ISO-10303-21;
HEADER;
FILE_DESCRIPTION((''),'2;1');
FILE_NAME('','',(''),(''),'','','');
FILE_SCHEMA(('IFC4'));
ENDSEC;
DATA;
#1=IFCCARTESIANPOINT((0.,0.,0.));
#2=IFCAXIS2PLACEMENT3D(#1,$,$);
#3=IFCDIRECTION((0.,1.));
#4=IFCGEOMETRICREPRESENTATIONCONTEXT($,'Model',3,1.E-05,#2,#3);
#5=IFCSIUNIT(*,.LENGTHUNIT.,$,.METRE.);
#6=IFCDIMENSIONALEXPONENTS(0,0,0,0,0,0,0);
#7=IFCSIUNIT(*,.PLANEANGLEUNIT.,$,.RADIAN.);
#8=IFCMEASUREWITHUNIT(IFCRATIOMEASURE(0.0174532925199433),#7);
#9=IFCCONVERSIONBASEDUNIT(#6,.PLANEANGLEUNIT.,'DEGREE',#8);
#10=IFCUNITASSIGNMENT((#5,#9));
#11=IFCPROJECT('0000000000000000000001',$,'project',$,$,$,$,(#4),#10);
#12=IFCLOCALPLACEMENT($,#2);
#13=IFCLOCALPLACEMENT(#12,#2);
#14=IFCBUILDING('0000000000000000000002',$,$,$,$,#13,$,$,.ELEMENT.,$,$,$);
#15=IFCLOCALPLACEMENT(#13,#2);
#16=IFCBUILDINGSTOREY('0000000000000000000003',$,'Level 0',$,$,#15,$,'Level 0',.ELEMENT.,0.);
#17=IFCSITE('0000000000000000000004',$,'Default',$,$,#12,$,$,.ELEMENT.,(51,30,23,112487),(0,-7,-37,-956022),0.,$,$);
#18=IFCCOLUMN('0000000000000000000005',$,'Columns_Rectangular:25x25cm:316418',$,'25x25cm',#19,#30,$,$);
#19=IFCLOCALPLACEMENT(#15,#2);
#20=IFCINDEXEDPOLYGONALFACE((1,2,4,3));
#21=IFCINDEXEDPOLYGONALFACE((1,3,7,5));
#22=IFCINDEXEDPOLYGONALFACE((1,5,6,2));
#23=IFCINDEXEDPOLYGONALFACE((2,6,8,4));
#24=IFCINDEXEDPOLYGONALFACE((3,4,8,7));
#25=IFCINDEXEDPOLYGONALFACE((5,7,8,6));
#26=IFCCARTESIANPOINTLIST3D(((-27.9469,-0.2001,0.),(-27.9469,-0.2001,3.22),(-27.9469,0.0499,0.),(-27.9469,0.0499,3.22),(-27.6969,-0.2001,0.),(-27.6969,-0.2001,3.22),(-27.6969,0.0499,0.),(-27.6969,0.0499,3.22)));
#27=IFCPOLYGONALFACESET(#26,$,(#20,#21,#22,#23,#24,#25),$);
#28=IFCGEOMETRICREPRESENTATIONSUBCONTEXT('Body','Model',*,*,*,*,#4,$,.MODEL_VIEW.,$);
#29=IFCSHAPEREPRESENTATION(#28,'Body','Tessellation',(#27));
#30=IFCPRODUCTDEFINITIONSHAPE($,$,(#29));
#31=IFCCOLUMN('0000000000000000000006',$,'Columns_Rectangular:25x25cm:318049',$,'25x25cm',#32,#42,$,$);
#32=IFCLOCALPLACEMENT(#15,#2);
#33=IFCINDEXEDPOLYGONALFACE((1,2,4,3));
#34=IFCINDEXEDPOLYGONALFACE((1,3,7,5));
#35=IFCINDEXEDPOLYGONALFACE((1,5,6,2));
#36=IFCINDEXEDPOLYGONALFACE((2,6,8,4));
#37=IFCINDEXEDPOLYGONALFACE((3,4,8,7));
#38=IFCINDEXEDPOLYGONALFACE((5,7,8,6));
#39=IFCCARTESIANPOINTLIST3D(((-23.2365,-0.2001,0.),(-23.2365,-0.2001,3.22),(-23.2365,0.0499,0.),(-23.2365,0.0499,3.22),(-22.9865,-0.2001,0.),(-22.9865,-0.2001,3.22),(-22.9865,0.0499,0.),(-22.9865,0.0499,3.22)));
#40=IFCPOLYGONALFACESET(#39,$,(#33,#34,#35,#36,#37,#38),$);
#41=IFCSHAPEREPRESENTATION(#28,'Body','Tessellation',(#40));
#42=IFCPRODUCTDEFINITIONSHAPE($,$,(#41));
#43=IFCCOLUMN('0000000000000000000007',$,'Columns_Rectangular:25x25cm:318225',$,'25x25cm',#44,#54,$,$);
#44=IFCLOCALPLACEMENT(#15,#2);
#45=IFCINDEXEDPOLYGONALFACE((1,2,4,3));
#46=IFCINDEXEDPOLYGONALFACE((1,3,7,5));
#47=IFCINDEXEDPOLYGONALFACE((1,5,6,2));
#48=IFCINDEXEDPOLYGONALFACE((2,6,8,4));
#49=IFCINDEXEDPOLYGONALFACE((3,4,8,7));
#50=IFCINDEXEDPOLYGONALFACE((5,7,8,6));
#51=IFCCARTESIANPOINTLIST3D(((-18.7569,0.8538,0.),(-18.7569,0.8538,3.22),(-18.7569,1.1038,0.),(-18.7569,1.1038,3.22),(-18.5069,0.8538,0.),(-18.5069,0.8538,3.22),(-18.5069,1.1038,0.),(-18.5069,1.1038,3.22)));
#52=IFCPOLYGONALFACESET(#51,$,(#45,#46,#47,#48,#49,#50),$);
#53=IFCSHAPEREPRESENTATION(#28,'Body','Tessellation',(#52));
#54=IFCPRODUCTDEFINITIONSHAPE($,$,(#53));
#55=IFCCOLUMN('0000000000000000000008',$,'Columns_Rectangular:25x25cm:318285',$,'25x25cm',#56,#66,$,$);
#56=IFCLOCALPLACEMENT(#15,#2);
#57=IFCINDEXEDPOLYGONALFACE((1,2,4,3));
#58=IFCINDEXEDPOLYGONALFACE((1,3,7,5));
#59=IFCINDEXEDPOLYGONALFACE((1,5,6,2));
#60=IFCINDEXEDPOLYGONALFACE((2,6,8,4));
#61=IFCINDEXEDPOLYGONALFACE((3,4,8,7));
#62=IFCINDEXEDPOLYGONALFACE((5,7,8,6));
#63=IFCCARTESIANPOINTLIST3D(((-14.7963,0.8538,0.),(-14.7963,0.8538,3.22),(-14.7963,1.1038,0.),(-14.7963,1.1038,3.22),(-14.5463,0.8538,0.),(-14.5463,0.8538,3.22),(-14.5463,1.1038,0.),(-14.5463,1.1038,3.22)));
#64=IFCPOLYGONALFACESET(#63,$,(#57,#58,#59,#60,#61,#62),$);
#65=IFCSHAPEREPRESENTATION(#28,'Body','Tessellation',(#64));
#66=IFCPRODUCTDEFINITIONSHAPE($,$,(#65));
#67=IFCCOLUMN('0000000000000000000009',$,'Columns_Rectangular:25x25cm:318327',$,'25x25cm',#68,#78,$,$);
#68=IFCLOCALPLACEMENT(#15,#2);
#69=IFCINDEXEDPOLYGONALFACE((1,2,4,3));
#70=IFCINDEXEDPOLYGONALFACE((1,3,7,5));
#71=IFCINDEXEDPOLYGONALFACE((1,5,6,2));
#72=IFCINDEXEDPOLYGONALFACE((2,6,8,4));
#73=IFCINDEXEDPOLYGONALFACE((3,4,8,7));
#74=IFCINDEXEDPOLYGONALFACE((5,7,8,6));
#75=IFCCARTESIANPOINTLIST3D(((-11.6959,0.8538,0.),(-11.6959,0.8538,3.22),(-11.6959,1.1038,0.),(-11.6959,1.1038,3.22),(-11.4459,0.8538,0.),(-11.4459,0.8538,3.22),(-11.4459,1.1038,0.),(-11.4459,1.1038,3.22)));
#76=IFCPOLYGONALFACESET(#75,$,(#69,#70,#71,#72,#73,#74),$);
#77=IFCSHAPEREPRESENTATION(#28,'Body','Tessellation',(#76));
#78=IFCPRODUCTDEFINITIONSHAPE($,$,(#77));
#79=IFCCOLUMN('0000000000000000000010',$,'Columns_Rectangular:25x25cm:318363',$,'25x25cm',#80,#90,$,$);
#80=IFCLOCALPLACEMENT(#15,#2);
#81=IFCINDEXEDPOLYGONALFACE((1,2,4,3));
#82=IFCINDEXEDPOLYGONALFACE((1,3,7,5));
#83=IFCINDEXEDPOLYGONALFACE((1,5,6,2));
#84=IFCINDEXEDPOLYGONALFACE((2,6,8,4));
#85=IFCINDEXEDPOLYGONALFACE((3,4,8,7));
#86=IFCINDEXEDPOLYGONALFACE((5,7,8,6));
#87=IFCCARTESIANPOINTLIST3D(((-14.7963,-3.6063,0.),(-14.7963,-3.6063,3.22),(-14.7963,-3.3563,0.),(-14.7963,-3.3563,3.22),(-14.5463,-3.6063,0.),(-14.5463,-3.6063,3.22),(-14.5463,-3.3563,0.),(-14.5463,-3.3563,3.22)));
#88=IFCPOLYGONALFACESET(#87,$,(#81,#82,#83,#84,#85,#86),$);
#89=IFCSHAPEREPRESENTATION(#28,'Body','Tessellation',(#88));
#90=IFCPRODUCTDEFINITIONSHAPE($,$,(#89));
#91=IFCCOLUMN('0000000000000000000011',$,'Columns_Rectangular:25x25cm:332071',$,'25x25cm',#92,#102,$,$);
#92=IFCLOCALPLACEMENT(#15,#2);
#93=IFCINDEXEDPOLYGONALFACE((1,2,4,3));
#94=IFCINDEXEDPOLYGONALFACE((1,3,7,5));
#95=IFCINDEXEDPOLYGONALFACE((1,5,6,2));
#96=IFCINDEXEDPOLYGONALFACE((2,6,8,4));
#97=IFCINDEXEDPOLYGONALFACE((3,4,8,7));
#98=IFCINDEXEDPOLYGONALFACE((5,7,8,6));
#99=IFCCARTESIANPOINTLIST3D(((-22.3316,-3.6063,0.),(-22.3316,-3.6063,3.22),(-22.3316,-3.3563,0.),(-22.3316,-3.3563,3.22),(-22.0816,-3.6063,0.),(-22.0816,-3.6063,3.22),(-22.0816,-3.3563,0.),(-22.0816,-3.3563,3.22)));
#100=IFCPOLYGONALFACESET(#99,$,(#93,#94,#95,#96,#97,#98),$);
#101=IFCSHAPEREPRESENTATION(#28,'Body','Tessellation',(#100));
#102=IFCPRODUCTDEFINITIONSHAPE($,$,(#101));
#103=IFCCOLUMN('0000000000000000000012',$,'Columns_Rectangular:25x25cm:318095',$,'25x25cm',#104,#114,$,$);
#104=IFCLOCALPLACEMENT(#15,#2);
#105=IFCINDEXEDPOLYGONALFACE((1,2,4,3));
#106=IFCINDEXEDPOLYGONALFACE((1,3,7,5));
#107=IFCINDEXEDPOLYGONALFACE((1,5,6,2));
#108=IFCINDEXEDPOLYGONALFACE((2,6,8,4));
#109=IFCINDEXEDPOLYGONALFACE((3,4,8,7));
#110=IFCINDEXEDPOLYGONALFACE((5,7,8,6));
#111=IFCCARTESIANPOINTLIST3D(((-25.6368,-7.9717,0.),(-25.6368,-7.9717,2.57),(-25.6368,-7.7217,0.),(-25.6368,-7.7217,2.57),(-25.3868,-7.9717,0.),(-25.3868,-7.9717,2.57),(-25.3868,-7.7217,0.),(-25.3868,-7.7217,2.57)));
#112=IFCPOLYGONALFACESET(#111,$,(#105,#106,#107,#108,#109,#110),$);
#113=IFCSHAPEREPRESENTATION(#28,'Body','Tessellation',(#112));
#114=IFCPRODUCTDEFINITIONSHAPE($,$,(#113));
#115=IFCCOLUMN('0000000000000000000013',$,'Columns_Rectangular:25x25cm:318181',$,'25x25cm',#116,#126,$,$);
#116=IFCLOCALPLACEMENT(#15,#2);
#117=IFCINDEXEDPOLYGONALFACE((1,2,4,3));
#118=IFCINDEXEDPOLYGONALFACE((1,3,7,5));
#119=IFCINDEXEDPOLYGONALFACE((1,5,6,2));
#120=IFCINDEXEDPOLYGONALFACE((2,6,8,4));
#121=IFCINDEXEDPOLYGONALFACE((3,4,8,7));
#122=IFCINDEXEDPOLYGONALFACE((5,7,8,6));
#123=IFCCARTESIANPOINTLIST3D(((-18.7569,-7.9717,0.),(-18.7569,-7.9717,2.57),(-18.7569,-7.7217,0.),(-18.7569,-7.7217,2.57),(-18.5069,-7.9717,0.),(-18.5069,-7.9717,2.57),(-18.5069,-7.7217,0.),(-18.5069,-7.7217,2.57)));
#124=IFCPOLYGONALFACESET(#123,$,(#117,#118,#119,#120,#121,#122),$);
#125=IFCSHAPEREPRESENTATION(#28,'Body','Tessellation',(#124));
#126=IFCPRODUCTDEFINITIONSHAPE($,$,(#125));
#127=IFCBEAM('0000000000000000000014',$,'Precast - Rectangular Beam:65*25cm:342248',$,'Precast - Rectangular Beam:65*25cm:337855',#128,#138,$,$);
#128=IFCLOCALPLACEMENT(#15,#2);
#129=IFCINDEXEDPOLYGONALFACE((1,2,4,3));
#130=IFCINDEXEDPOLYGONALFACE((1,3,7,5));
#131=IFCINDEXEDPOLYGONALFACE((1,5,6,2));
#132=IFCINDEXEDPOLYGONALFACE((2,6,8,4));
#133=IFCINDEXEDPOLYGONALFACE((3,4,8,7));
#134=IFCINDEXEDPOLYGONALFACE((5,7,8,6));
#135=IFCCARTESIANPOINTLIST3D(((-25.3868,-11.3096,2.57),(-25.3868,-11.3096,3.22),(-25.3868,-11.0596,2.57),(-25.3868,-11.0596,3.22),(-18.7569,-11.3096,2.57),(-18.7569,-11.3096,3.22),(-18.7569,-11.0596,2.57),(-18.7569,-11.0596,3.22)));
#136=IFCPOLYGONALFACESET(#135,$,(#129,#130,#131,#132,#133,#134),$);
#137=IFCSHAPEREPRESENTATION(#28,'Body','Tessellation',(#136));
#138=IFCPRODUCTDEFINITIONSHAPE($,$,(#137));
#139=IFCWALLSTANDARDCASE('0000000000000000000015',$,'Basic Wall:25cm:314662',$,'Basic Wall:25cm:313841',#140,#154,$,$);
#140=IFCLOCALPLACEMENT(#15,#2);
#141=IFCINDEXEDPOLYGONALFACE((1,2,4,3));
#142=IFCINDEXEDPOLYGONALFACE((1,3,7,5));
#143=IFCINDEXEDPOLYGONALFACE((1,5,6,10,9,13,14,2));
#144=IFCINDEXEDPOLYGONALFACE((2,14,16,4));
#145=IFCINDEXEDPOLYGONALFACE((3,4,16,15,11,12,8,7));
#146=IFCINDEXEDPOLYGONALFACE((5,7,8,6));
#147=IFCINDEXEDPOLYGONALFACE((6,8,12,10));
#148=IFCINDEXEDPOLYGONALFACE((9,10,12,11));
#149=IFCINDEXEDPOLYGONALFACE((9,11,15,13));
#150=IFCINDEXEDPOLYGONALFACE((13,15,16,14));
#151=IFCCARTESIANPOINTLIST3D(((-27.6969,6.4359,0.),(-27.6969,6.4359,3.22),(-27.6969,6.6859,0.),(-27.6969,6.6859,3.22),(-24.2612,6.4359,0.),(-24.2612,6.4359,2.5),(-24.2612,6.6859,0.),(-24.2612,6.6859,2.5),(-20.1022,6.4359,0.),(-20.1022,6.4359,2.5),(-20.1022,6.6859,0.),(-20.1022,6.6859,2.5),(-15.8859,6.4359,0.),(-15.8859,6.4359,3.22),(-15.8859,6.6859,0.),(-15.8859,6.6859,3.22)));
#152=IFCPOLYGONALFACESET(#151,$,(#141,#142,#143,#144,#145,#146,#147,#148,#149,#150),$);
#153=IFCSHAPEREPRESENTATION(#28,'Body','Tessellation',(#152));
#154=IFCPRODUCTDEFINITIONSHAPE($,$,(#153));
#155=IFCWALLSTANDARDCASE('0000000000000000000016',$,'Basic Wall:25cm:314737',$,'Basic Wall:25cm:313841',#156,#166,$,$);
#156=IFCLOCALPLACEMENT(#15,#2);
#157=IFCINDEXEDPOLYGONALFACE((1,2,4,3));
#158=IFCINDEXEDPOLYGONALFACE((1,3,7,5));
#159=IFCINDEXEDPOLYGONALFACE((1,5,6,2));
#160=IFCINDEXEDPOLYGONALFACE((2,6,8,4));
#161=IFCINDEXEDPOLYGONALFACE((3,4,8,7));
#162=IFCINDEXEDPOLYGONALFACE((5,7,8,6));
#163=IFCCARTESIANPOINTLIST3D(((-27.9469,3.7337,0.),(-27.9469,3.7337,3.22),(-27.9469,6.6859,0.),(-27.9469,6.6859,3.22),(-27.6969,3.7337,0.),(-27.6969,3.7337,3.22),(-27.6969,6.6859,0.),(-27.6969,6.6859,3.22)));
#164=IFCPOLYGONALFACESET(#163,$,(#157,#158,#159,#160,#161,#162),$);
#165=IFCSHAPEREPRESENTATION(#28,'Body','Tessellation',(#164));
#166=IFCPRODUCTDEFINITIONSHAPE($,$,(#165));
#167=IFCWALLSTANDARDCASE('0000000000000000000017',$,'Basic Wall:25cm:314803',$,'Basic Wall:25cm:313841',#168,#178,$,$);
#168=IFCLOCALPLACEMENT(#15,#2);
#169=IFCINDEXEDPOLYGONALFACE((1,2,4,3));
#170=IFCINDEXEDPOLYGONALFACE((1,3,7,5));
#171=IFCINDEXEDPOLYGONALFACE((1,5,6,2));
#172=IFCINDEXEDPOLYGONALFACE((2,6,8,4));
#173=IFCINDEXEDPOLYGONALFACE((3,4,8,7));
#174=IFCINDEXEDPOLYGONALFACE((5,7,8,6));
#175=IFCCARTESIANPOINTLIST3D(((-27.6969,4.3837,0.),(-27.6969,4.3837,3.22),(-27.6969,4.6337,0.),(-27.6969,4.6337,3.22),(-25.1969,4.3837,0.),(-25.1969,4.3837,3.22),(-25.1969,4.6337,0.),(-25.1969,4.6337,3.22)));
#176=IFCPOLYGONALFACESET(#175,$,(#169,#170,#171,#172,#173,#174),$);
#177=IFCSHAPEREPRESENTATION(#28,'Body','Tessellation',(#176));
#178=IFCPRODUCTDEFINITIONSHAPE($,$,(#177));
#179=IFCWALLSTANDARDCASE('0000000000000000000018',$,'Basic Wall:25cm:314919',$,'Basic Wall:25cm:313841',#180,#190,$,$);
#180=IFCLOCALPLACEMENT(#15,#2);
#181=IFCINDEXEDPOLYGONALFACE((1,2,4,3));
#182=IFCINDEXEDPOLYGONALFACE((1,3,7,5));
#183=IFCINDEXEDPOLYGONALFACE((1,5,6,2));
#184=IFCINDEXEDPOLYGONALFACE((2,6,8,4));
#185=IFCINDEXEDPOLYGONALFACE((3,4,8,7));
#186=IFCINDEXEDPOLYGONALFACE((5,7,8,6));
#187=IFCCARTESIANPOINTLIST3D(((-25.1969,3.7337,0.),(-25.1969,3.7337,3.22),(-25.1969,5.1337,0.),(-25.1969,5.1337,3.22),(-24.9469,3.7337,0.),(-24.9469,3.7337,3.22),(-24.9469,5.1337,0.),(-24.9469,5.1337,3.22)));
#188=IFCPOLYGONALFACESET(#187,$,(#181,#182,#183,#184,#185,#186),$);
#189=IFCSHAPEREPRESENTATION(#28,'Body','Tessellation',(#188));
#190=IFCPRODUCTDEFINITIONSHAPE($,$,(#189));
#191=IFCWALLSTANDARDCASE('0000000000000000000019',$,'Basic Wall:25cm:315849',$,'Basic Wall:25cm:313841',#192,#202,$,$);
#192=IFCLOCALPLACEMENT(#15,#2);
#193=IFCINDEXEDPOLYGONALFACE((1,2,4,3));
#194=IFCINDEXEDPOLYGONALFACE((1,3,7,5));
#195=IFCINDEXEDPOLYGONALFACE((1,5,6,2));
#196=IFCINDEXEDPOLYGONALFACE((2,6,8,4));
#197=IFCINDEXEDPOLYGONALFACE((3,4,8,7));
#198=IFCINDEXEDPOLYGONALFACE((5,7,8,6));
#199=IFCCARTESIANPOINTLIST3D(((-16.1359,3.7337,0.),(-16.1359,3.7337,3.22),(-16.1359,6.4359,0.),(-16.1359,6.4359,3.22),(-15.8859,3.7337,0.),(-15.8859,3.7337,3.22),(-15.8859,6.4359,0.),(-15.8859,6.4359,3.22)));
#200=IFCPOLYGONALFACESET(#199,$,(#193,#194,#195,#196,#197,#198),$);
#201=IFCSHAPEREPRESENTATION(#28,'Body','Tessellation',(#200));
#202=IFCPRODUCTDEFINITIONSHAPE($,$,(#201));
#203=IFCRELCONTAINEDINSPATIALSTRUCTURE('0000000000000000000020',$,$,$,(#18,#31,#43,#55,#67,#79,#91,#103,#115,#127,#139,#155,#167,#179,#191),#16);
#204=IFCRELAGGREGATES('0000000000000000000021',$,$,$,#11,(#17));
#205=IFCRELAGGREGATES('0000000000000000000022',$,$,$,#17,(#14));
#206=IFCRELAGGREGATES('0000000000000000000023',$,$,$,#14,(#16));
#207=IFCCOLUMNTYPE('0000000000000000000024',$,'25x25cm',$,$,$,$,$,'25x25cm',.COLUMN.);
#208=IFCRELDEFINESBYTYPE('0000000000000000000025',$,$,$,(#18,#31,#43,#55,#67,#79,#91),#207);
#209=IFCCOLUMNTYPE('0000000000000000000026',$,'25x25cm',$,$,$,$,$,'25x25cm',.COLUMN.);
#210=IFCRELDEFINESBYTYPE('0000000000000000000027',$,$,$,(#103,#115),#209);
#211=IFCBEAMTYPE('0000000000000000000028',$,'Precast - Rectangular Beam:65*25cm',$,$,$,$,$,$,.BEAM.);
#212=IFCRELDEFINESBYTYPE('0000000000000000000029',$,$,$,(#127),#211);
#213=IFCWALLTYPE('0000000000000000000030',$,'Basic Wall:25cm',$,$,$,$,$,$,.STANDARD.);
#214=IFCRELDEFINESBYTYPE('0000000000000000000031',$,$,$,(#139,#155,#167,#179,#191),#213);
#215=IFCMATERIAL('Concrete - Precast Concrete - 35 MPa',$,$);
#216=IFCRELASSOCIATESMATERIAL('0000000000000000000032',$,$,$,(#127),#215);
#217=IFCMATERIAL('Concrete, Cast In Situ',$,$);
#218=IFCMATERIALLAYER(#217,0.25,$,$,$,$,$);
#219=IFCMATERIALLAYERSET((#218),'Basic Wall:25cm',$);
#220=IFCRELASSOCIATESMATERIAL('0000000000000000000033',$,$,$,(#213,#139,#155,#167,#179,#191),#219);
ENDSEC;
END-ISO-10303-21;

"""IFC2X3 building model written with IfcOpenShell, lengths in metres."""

from ifc_helpers import new_model, entity, si_unit, converted_unit, direction, frame, frame_2d, origin, origin_2d_with_axis, place, context, subcontext, project, spatial, rectangle, extrude, source, transform, mapped, material, layer, layer_set, layer_usage, type_object, type_shapes, element, save


model = new_model("IFC2X3")

# Units and contexts
model_context = context("Model", 3, precision=1e-05, world=origin(), true_north=direction((0.0, 1.0)))
body_context = subcontext(model_context, "Body", "Model", "MODEL_VIEW")
ifc_project = project(units=[si_unit("LENGTHUNIT", "METRE"), converted_unit("PLANEANGLEUNIT", "DEGREE", entity("IfcRatioMeasure", 0.0174532925199433), si_unit("PLANEANGLEUNIT", "RADIAN"), dimensions=[0, 0, 0, 0, 0, 0, 0])], contexts=[model_context])

# Site, building, storey
site_placement = place(None, origin())
site = spatial("IfcSite", under=ifc_project, at=site_placement, Name="Default", CompositionType="ELEMENT", RefLatitude=(51, 30, 23, 112487), RefLongitude=(0, -7, -37, -956022), RefElevation=0.0)
building_placement = place(site_placement, origin())
building = spatial("IfcBuilding", under=site, at=building_placement, CompositionType="ELEMENT")
storey_placement = place(building_placement, origin())
storey = spatial("IfcBuildingStorey", under=building, at=storey_placement, Name="Level 0", LongName="Level 0", CompositionType="ELEMENT", Elevation=0.0)

# Columns
column_type_1 = type_object("IfcColumnType", Name="25x25cm", ElementType="25x25cm", PredefinedType="COLUMN")
shared_shape_1 = source(origin(), body_context, "Body", "SweptSolid", [
    extrude(rectangle(XDim=0.25, YDim=0.25, at=origin_2d_with_axis()), frame((0.0, 0.0, 0.0), z_axis=(0.0, 0.0, 1.0), x_axis=(0.0, -1.0, 0.0)), (0.0, 0.0, 1.0), 3.22),
])
type_shapes(column_type_1, [shared_shape_1])
for number, where, name in (
    (1, (-27.8219, -0.0751, 0.0), "Columns_Rectangular:25x25cm:316418"),
    (2, (-23.1115, -0.0751, 0.0), "Columns_Rectangular:25x25cm:318049"),
    (3, (-18.6319, 0.9788, 0.0), "Columns_Rectangular:25x25cm:318225"),
    (4, (-14.6713, 0.9788, 0.0), "Columns_Rectangular:25x25cm:318285"),
    (5, (-11.5709, 0.9788, 0.0), "Columns_Rectangular:25x25cm:318327"),
    (6, (-14.6713, -3.4813, 0.0), "Columns_Rectangular:25x25cm:318363"),
    (7, (-22.2066, -3.4813, 0.0), "Columns_Rectangular:25x25cm:332071"),
):
    element("IfcColumn", number, at=place(storey_placement, frame(where)), inside=storey, type_object=column_type_1, Name=name, ObjectType="25x25cm", context=body_context, shape_type="MappedRepresentation", body=[
        mapped(shared_shape_1, transform((0.0, 0.0, 0.0), scale=1.0)),
    ])
column_type_2 = type_object("IfcColumnType", Name="25x25cm", ElementType="25x25cm", PredefinedType="COLUMN")
shared_shape_2 = source(origin(), body_context, "Body", "SweptSolid", [
    extrude(rectangle(XDim=0.25, YDim=0.25, at=origin_2d_with_axis()), frame((0.0, 0.0, 0.0), z_axis=(0.0, 0.0, 1.0), x_axis=(0.0, -1.0, 0.0)), (0.0, 0.0, 1.0), 2.57),
])
type_shapes(column_type_2, [shared_shape_2])
for number, where, name in (
    (8, (-25.5118, -7.8467, 0.0), "Columns_Rectangular:25x25cm:318095"),
    (9, (-18.6319, -7.8467, 0.0), "Columns_Rectangular:25x25cm:318181"),
):
    element("IfcColumn", number, at=place(storey_placement, frame(where)), inside=storey, type_object=column_type_2, Name=name, ObjectType="25x25cm", context=body_context, shape_type="MappedRepresentation", body=[
        mapped(shared_shape_2, transform((0.0, 0.0, 0.0), scale=1.0)),
    ])

# Beam
ifc_material_1 = material(Name="Concrete - Precast Concrete - 35 MPa")
beam_type = type_object("IfcBeamType", Name="Precast - Rectangular Beam:65*25cm", PredefinedType="BEAM")
beam_placement = place(storey_placement, frame((-24.7617, -11.1846, 3.22)))
element("IfcBeam", 10, at=beam_placement, inside=storey, type_object=beam_type, material=ifc_material_1, Name="Precast - Rectangular Beam:65*25cm:342248", ObjectType="Precast - Rectangular Beam:65*25cm:337855", context=body_context, shape_type="SweptSolid", body=[
    extrude(rectangle(XDim=0.65, YDim=0.25, at=frame_2d((0.0, 0.0), x_axis=(1.0, 0.0))), frame((-0.6251, 0.0, -0.325), z_axis=(1.0, 0.0, 0.0), x_axis=(0.0, 0.0, -1.0)), (0.0, 0.0, 1.0), 6.63),
])

# Wall, opening
ifc_material_2 = material(Name="Concrete, Cast In Situ")
ifc_layer = layer(ifc_material_2, 0.25)
ifc_layer_set = layer_set([ifc_layer], Name="Basic Wall:25cm")
ifc_layer_usage_1 = layer_usage(ifc_layer_set, "AXIS2", "NEGATIVE", 0.125)
wall_type = type_object("IfcWallType", Name="Basic Wall:25cm", PredefinedType="STANDARD", material=ifc_layer_set)
wall_1_placement = place(storey_placement, frame((-15.8859, 6.5609, 0.0), z_axis=(0.0, 0.0, 1.0), x_axis=(-1.0, 0.0, 0.0)))
wall_1 = element("IfcWallStandardCase", 11, at=wall_1_placement, inside=storey, type_object=wall_type, material=ifc_layer_usage_1, Name="Basic Wall:25cm:314662", ObjectType="Basic Wall:25cm:313841", context=body_context, shape_type="SweptSolid", body=[
    extrude(rectangle(XDim=11.811, YDim=0.25, at=frame_2d((5.9055, 0.0), x_axis=(-1.0, 0.0))), origin(), (0.0, 0.0, 1.0), 3.22),
])
opening_1_placement = place(wall_1_placement, origin())
element("IfcOpeningElement", 12, at=opening_1_placement, cuts=wall_1, ObjectType="Opening", context=body_context, shape_type="SweptSolid", body=[
    extrude(rectangle(XDim=2.5, YDim=4.1591, at=origin_2d_with_axis()), frame((6.2958, -0.125, 1.25), z_axis=(0.0, 1.0, 0.0), x_axis=(0.0, 0.0, -1.0)), (0.0, 0.0, 1.0), 0.25),
])

# Walls
ifc_layer_usage_2 = layer_usage(ifc_layer_set, "AXIS2", "NEGATIVE", 0.125)
wall_2_placement = place(storey_placement, frame((-27.8219, 6.6859, 0.0), z_axis=(0.0, 0.0, 1.0), x_axis=(0.0, -1.0, 0.0)))
element("IfcWallStandardCase", 13, at=wall_2_placement, inside=storey, type_object=wall_type, material=ifc_layer_usage_2, Name="Basic Wall:25cm:314737", ObjectType="Basic Wall:25cm:313841", context=body_context, shape_type="SweptSolid", body=[
    extrude(rectangle(XDim=2.9523, YDim=0.25, at=frame_2d((1.4761, 0.0), x_axis=(-1.0, 0.0))), origin(), (0.0, 0.0, 1.0), 3.22),
])
ifc_layer_usage_3 = layer_usage(ifc_layer_set, "AXIS2", "POSITIVE", -0.125)
wall_3_placement = place(storey_placement, frame((-27.6969, 4.5087, 0.0)))
element("IfcWallStandardCase", 14, at=wall_3_placement, inside=storey, type_object=wall_type, material=ifc_layer_usage_3, Name="Basic Wall:25cm:314803", ObjectType="Basic Wall:25cm:313841", context=body_context, shape_type="SweptSolid", body=[
    extrude(rectangle(XDim=2.5, YDim=0.25, at=frame_2d((1.25, 0.0), x_axis=(-1.0, 0.0))), origin(), (0.0, 0.0, 1.0), 3.22),
])
ifc_layer_usage_4 = layer_usage(ifc_layer_set, "AXIS2", "NEGATIVE", 0.125)
wall_4_placement = place(storey_placement, frame((-25.0719, 5.1337, 0.0), z_axis=(0.0, 0.0, 1.0), x_axis=(0.0, -1.0, 0.0)))
element("IfcWallStandardCase", 15, at=wall_4_placement, inside=storey, type_object=wall_type, material=ifc_layer_usage_4, Name="Basic Wall:25cm:314919", ObjectType="Basic Wall:25cm:313841", context=body_context, shape_type="SweptSolid", body=[
    extrude(rectangle(XDim=1.4, YDim=0.25, at=frame_2d((0.7, 0.0), x_axis=(-1.0, 0.0))), origin(), (0.0, 0.0, 1.0), 3.22),
])
ifc_layer_usage_5 = layer_usage(ifc_layer_set, "AXIS2", "POSITIVE", -0.125)
wall_5_placement = place(storey_placement, frame((-16.0109, 6.4359, 0.0), z_axis=(0.0, 0.0, 1.0), x_axis=(0.0, -1.0, 0.0)))
element("IfcWallStandardCase", 16, at=wall_5_placement, inside=storey, type_object=wall_type, material=ifc_layer_usage_5, Name="Basic Wall:25cm:315849", ObjectType="Basic Wall:25cm:313841", context=body_context, shape_type="SweptSolid", body=[
    extrude(rectangle(XDim=2.7022, YDim=0.25, at=frame_2d((1.3511, 0.0), x_axis=(-1.0, 0.0))), origin(), (0.0, 0.0, 1.0), 3.22),
])

save(model, "model.ifc")
